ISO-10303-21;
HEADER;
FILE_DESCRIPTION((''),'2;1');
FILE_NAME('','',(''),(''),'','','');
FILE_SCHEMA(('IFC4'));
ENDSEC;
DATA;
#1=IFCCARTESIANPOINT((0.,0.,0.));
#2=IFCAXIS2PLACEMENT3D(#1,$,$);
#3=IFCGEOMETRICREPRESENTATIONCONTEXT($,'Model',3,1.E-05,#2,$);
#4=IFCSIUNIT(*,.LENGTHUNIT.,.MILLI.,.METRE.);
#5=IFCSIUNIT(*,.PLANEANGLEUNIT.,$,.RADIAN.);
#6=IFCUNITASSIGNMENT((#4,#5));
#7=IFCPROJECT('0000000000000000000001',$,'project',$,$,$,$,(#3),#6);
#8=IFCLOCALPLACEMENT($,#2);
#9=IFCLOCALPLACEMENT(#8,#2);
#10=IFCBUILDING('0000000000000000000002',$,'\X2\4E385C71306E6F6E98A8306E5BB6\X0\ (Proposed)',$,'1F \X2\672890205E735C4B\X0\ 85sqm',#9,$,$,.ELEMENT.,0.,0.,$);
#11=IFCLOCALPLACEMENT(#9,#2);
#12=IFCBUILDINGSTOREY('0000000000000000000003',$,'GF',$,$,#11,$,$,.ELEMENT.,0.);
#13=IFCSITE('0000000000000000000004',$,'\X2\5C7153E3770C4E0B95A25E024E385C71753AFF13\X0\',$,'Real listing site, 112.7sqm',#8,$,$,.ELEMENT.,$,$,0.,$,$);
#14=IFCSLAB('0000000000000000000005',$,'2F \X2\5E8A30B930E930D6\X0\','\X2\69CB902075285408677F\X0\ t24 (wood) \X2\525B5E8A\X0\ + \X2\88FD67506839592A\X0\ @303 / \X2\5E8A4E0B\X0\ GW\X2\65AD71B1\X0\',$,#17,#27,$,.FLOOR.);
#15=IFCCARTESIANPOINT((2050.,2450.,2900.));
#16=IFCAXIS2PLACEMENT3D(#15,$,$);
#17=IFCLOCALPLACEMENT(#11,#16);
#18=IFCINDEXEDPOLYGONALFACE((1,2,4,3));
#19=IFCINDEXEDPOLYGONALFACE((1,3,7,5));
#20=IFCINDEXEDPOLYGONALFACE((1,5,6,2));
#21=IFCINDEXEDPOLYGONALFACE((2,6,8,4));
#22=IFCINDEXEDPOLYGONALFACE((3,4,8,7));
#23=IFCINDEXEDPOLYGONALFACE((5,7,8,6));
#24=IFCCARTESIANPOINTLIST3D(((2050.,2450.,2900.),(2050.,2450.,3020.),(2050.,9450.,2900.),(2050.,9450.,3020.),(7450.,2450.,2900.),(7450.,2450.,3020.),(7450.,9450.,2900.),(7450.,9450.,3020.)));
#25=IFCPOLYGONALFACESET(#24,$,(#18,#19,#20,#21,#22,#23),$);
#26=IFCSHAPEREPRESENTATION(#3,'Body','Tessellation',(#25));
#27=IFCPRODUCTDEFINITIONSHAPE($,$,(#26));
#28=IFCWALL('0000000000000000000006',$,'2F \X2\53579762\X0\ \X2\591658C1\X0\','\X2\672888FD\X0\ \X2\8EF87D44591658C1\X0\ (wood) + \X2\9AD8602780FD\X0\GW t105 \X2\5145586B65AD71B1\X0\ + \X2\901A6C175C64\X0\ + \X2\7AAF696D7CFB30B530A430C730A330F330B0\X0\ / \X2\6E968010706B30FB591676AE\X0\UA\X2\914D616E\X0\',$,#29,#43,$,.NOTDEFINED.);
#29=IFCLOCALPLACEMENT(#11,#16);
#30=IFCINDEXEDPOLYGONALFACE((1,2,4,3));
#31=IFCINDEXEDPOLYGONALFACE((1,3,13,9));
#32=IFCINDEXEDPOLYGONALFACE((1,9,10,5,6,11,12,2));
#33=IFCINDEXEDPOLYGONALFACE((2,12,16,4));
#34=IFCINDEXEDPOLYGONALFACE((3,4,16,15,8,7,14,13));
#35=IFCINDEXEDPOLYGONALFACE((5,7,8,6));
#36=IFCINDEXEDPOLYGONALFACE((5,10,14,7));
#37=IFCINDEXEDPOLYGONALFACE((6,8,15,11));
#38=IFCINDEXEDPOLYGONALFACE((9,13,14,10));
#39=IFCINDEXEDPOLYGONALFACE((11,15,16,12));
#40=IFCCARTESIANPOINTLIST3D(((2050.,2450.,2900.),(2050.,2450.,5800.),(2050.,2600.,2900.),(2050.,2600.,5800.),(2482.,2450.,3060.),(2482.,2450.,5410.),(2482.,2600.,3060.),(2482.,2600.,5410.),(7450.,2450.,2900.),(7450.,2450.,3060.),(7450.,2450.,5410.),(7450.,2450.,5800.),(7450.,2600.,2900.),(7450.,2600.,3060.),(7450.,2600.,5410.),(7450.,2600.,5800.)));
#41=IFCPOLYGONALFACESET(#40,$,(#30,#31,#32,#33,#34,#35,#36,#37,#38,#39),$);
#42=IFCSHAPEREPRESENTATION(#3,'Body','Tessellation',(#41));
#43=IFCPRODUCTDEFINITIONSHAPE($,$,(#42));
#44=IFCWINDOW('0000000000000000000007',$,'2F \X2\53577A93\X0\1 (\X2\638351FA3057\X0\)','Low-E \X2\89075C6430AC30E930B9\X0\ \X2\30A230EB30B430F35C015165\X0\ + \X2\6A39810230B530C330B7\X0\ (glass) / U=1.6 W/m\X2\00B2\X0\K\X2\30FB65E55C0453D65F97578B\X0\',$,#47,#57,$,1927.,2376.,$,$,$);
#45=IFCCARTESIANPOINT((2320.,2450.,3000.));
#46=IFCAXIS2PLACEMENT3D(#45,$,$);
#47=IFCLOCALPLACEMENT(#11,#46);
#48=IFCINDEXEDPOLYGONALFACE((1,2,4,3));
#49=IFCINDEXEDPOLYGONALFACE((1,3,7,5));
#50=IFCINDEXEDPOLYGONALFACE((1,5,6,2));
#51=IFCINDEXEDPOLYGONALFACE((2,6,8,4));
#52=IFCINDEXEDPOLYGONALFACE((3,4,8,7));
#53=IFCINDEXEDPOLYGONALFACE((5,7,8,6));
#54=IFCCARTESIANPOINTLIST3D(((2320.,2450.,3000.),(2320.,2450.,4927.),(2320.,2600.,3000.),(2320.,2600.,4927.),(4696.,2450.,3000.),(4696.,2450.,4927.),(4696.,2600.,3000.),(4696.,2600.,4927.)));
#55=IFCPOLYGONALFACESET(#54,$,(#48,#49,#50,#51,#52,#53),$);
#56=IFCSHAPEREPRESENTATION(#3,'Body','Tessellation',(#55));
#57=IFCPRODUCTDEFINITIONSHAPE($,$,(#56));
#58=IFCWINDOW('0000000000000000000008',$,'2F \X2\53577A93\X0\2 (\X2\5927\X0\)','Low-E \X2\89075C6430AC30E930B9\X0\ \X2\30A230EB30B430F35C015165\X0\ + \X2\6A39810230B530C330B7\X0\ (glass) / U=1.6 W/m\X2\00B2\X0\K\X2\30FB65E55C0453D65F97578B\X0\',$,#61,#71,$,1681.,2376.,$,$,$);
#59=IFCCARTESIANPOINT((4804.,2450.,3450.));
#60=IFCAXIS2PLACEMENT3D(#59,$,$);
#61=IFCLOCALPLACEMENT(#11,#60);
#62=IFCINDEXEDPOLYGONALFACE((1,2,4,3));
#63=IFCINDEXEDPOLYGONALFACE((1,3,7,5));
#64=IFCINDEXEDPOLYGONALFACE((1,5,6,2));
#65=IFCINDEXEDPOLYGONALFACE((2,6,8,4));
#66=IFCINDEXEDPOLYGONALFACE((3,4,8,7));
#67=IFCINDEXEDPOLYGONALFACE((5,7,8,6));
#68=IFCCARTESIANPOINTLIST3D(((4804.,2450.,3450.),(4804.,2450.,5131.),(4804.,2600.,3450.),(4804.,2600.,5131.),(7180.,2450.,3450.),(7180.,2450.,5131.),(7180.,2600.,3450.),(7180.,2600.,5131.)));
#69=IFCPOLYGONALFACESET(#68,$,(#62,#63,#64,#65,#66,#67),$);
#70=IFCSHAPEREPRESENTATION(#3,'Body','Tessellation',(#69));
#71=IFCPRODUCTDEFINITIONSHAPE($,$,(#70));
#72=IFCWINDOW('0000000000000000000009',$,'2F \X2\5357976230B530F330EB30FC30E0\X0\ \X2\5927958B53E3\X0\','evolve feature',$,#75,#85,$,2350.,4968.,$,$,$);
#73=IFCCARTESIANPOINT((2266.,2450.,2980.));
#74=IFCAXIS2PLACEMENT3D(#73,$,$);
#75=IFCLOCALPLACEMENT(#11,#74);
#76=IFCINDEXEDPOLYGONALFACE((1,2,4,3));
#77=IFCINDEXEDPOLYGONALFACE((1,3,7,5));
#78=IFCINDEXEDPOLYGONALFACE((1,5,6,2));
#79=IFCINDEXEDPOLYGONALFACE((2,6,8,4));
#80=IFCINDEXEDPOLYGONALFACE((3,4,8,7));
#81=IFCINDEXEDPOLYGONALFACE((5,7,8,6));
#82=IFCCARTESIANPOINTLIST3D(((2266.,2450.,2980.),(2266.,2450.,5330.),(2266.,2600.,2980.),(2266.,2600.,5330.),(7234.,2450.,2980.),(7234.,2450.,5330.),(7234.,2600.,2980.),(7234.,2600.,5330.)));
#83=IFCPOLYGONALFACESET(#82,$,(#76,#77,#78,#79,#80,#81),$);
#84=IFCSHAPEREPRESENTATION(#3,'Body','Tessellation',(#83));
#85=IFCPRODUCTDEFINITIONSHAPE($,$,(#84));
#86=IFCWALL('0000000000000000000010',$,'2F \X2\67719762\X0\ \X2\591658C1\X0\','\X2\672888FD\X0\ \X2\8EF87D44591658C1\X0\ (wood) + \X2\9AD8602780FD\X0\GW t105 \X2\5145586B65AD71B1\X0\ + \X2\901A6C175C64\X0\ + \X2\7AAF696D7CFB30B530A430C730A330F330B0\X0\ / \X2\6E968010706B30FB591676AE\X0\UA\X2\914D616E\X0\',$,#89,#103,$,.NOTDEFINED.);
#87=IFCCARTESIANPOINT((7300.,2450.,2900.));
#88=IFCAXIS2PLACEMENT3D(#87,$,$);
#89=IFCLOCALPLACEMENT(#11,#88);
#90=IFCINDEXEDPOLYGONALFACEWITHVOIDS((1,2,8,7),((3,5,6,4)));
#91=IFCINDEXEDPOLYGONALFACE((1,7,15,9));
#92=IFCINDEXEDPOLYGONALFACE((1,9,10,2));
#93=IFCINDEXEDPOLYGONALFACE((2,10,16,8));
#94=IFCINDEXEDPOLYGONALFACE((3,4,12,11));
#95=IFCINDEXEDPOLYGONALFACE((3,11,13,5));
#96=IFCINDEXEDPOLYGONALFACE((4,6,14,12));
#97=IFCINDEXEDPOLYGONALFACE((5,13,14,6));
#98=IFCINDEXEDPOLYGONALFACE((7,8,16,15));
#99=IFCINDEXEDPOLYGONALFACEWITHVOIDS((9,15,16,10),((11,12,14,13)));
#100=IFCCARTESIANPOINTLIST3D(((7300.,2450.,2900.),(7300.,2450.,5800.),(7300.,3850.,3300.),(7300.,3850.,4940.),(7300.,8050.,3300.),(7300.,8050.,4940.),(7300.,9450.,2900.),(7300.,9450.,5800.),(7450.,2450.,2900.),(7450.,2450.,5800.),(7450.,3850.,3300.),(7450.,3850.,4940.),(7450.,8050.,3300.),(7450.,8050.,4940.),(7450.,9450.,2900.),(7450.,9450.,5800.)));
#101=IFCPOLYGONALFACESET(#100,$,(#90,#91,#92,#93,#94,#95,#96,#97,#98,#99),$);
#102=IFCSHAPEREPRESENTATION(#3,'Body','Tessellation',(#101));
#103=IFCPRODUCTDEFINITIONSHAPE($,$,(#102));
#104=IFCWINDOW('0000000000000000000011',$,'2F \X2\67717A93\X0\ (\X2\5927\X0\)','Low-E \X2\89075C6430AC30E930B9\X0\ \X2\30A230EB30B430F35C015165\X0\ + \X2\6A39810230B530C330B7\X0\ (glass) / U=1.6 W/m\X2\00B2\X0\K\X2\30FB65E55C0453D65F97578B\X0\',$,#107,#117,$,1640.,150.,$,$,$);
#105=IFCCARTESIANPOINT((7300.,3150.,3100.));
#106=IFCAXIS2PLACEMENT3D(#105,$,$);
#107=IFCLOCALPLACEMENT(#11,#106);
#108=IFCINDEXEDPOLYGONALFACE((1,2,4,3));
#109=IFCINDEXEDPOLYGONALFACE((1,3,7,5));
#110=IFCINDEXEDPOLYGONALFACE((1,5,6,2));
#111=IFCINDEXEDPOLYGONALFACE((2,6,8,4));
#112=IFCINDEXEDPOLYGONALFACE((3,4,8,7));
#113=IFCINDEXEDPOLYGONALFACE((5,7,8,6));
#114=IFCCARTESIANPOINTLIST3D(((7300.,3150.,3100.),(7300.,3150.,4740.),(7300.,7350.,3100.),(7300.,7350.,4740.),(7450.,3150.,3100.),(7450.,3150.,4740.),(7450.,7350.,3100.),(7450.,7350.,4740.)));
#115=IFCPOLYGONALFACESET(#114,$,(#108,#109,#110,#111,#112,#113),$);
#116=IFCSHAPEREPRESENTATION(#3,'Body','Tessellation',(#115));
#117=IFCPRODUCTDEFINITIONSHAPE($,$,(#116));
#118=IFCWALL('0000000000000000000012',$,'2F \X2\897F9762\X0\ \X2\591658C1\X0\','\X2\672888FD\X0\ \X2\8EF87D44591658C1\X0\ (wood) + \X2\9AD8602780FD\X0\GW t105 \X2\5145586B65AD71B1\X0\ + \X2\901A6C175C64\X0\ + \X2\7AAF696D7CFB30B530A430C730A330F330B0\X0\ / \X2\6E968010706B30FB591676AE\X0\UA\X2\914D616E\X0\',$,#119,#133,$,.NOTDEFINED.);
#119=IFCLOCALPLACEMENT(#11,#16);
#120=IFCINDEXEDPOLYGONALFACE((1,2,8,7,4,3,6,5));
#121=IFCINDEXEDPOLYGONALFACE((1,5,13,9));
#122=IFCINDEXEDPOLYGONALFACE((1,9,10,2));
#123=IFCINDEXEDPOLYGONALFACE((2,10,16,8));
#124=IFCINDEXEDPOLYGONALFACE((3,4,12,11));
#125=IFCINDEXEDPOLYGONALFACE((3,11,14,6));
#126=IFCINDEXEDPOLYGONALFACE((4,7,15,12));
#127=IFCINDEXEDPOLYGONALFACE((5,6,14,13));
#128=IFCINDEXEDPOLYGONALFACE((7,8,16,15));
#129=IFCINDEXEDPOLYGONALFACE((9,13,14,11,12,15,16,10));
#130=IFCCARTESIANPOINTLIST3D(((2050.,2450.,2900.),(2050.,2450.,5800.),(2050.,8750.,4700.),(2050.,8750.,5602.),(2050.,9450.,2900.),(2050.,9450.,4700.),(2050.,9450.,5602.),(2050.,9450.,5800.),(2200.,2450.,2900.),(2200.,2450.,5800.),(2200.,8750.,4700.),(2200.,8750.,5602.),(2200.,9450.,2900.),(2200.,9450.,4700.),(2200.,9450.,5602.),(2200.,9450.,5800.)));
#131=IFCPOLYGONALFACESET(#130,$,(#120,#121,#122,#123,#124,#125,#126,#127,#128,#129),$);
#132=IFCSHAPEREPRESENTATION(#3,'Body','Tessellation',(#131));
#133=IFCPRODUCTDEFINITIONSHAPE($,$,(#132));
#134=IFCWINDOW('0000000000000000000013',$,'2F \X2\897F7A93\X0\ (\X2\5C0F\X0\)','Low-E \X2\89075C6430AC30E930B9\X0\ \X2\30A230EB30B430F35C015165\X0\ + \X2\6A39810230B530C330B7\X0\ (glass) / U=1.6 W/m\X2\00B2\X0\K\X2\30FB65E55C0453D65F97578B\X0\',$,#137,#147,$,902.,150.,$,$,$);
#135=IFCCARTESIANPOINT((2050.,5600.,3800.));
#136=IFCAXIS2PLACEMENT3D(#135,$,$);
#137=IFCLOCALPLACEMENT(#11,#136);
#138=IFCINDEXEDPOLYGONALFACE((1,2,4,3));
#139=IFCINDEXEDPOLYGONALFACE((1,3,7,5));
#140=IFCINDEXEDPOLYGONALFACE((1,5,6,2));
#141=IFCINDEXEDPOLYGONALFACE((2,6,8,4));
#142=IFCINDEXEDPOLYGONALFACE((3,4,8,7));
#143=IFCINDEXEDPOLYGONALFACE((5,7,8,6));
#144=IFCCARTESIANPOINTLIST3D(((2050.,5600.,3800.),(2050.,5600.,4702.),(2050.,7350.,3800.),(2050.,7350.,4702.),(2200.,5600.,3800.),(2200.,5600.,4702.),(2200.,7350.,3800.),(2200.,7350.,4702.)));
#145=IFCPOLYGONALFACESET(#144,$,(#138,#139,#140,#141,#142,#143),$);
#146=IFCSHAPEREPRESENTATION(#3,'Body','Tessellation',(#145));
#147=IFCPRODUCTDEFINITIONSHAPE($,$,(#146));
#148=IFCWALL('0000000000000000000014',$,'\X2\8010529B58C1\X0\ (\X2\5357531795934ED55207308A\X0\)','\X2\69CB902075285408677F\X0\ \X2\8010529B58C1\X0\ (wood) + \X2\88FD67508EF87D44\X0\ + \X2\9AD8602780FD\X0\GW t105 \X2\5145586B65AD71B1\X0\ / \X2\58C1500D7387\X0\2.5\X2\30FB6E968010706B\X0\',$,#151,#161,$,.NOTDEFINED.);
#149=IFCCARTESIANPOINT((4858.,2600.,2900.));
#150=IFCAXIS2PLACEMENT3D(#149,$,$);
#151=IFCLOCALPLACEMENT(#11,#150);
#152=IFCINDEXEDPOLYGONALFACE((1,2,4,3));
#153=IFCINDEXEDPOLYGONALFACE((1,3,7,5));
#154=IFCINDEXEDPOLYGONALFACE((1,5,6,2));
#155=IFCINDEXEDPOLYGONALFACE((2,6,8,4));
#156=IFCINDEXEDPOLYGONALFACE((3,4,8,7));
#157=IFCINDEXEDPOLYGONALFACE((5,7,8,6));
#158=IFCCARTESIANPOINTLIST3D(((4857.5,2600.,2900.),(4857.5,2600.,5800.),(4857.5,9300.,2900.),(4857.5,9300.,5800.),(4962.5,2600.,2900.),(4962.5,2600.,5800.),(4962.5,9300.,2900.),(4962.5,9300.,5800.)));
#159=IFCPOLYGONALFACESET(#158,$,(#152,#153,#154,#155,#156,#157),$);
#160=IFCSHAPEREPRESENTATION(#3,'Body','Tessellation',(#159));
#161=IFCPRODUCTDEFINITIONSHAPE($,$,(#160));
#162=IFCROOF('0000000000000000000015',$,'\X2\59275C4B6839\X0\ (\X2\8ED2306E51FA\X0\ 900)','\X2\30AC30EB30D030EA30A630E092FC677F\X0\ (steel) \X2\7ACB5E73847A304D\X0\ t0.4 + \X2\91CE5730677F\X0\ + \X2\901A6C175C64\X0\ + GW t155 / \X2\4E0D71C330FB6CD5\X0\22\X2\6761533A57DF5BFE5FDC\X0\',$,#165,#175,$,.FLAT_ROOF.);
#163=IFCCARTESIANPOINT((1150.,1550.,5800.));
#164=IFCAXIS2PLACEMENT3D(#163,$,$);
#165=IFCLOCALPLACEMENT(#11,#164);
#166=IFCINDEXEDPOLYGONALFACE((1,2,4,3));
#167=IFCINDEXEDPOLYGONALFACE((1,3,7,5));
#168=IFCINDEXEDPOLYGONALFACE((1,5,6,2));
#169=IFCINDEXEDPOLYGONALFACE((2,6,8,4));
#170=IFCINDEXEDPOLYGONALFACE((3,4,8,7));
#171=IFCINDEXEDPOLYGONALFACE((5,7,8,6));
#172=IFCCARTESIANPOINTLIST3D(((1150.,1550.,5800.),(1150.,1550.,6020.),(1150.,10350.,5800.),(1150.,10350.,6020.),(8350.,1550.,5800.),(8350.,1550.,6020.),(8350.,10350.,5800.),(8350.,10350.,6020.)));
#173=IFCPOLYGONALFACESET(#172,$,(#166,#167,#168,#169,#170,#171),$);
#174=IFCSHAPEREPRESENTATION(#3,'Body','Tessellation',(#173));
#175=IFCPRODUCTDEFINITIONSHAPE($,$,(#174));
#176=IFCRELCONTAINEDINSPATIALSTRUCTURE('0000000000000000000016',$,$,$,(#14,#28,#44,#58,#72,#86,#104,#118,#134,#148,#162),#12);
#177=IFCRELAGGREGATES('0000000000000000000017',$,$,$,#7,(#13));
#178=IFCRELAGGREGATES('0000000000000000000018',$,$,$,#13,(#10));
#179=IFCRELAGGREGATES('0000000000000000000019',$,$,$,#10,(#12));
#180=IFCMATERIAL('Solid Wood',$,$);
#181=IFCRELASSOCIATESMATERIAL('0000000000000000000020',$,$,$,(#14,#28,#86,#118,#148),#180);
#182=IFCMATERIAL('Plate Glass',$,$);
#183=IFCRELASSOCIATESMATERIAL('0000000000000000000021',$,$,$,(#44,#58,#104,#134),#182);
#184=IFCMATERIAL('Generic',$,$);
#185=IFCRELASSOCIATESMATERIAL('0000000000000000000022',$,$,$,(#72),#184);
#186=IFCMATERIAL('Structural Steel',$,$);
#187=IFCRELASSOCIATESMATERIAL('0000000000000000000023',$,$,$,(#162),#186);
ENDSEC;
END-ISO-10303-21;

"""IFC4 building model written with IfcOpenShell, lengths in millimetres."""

from ifc_helpers import new_model, si_unit, frame, frame_2d, origin, place, context, project, spatial, rectangle, extrude, material, element, fill, save


model = new_model("IFC4")

# Units and contexts
model_context = context("Model", 3, precision=1e-05, world=origin())
ifc_project = project(units=[si_unit("LENGTHUNIT", "METRE", prefix="MILLI"), si_unit("PLANEANGLEUNIT", "RADIAN")], contexts=[model_context])

# Site, building, storey
site_placement = place(None, origin())
site = spatial("IfcSite", under=ifc_project, at=site_placement, Name="山口県下関市丸山町３", ObjectType="Real listing site, 112.7sqm", CompositionType="ELEMENT", RefElevation=0.0)
building_placement = place(site_placement, origin())
building = spatial("IfcBuilding", under=site, at=building_placement, Name="丸山の潮風の家 (Proposed)", ObjectType="1F 木造平屋 85sqm", CompositionType="ELEMENT", ElevationOfRefHeight=0.0, ElevationOfTerrain=0.0)
storey_placement = place(building_placement, origin())
storey = spatial("IfcBuildingStorey", under=building, at=storey_placement, Name="GF", CompositionType="ELEMENT", Elevation=0.0)

# Slab
ifc_material_1 = material(Name="Solid Wood")
slab_placement = place(storey_placement, frame((2050.0, 2450.0, 2900.0)))
element("IfcSlab", 1, at=slab_placement, inside=storey, material=ifc_material_1, Name="2F 床スラブ", Description="構造用合板 t24 (wood) 剛床 + 製材根太 @303 / 床下 GW断熱", PredefinedType="FLOOR", context=model_context, shape_type="SweptSolid", body=[
    extrude(rectangle(XDim=5400.0, YDim=7000.0, at=frame_2d((2700.0, 3500.0))), frame((2050.0, 2450.0, 2900.0)), (0.0, 0.0, 1.0), 120.0),
])

# Wall, openings, windows
wall_1_placement = place(storey_placement, frame((2050.0, 2450.0, 2900.0)))
wall_1 = element("IfcWall", 2, at=wall_1_placement, inside=storey, material=ifc_material_1, Name="2F 南面 外壁", Description="木製 軸組外壁 (wood) + 高性能GW t105 充填断熱 + 通気層 + 窯業系サイディング / 準耐火・外皮UA配慮", PredefinedType="NOTDEFINED", context=model_context, shape_type="SweptSolid", body=[
    extrude(rectangle(XDim=5400.0, YDim=150.0, at=frame_2d((2700.0, 75.0))), frame((2050.0, 2450.0, 2900.0)), (0.0, 0.0, 1.0), 2900.0),
])
opening_1_placement = place(storey_placement, frame((2320.0, 2450.0, 3000.0)))
opening_1 = element("IfcOpeningElement", 3, at=opening_1_placement, cuts=wall_1, PredefinedType="NOTDEFINED", context=model_context, shape_type="SweptSolid", body=[
    extrude(rectangle(XDim=2376.0, YDim=150.0, at=frame_2d((1188.0, 75.0))), frame((2320.0, 2450.0, 3000.0)), (0.0, 0.0, 1.0), 1927.0),
])
opening_2_placement = place(storey_placement, frame((4804.0, 2450.0, 3450.0)))
opening_2 = element("IfcOpeningElement", 4, at=opening_2_placement, cuts=wall_1, PredefinedType="NOTDEFINED", context=model_context, shape_type="SweptSolid", body=[
    extrude(rectangle(XDim=2376.0, YDim=150.0, at=frame_2d((1188.0, 75.0))), frame((4804.0, 2450.0, 3450.0)), (0.0, 0.0, 1.0), 1681.0),
])
opening_3_placement = place(storey_placement, frame((2266.0, 2450.0, 2980.0)))
opening_3 = element("IfcOpeningElement", 5, at=opening_3_placement, cuts=wall_1, PredefinedType="NOTDEFINED", context=model_context, shape_type="SweptSolid", body=[
    extrude(rectangle(XDim=4968.0, YDim=150.0, at=frame_2d((2484.0, 75.0))), frame((2266.0, 2450.0, 2980.0)), (0.0, 0.0, 1.0), 2350.0),
])
ifc_material_2 = material(Name="Plate Glass")
window_1_placement = place(storey_placement, frame((2320.0, 2450.0, 3000.0)))
window_1 = element("IfcWindow", 6, at=window_1_placement, inside=storey, material=ifc_material_2, Name="2F 南窓1 (掃出し)", Description="Low-E 複層ガラス アルゴン封入 + 樹脂サッシ (glass) / U=1.6 W/m²K・日射取得型", OverallHeight=1927.0, OverallWidth=2376.0, context=model_context, shape_type="SweptSolid", body=[
    extrude(rectangle(XDim=2376.0, YDim=150.0, at=frame_2d((1188.0, 75.0))), frame((2320.0, 2450.0, 3000.0)), (0.0, 0.0, 1.0), 1927.0),
])
fill(opening_1, window_1)
window_2_placement = place(storey_placement, frame((4804.0, 2450.0, 3450.0)))
window_2 = element("IfcWindow", 7, at=window_2_placement, inside=storey, material=ifc_material_2, Name="2F 南窓2 (大)", Description="Low-E 複層ガラス アルゴン封入 + 樹脂サッシ (glass) / U=1.6 W/m²K・日射取得型", OverallHeight=1681.0, OverallWidth=2376.0, context=model_context, shape_type="SweptSolid", body=[
    extrude(rectangle(XDim=2376.0, YDim=150.0, at=frame_2d((1188.0, 75.0))), frame((4804.0, 2450.0, 3450.0)), (0.0, 0.0, 1.0), 1681.0),
])
fill(opening_2, window_2)
ifc_material_3 = material(Name="Generic")
window_3_placement = place(storey_placement, frame((2266.0, 2450.0, 2980.0)))
window_3 = element("IfcWindow", 8, at=window_3_placement, inside=storey, material=ifc_material_3, Name="2F 南面サンルーム 大開口", Description="evolve feature", OverallHeight=2350.0, OverallWidth=4968.0, context=model_context, shape_type="SweptSolid", body=[
    extrude(rectangle(XDim=4968.0, YDim=150.0, at=frame_2d((2484.0, 75.0))), frame((2266.0, 2450.0, 2980.0)), (0.0, 0.0, 1.0), 2350.0),
])
fill(opening_3, window_3)

# Walls, openings, windows
wall_2_placement = place(storey_placement, frame((7300.0, 2450.0, 2900.0)))
wall_2 = element("IfcWall", 9, at=wall_2_placement, inside=storey, material=ifc_material_1, Name="2F 東面 外壁", Description="木製 軸組外壁 (wood) + 高性能GW t105 充填断熱 + 通気層 + 窯業系サイディング / 準耐火・外皮UA配慮", PredefinedType="NOTDEFINED", context=model_context, shape_type="SweptSolid", body=[
    extrude(rectangle(XDim=150.0, YDim=7000.0, at=frame_2d((75.0, 3500.0))), frame((7300.0, 2450.0, 2900.0)), (0.0, 0.0, 1.0), 2900.0),
])
opening_4_placement = place(storey_placement, frame((7300.0, 3150.0, 3100.0)))
opening_4 = element("IfcOpeningElement", 10, at=opening_4_placement, cuts=wall_2, PredefinedType="NOTDEFINED", context=model_context, shape_type="SweptSolid", body=[
    extrude(rectangle(XDim=150.0, YDim=4200.0, at=frame_2d((75.0, 2100.0))), frame((7300.0, 3150.0, 3100.0)), (0.0, 0.0, 1.0), 1640.0),
])
window_4_placement = place(storey_placement, frame((7300.0, 3150.0, 3100.0)))
window_4 = element("IfcWindow", 11, at=window_4_placement, inside=storey, material=ifc_material_2, Name="2F 東窓 (大)", Description="Low-E 複層ガラス アルゴン封入 + 樹脂サッシ (glass) / U=1.6 W/m²K・日射取得型", OverallHeight=1640.0, OverallWidth=150.0, context=model_context, shape_type="SweptSolid", body=[
    extrude(rectangle(XDim=150.0, YDim=4200.0, at=frame_2d((75.0, 2100.0))), frame((7300.0, 3150.0, 3100.0)), (0.0, 0.0, 1.0), 1640.0),
])
fill(opening_4, window_4)
wall_3_placement = place(storey_placement, frame((2050.0, 2450.0, 2900.0)))
wall_3 = element("IfcWall", 12, at=wall_3_placement, inside=storey, material=ifc_material_1, Name="2F 西面 外壁", Description="木製 軸組外壁 (wood) + 高性能GW t105 充填断熱 + 通気層 + 窯業系サイディング / 準耐火・外皮UA配慮", PredefinedType="NOTDEFINED", context=model_context, shape_type="SweptSolid", body=[
    extrude(rectangle(XDim=150.0, YDim=7000.0, at=frame_2d((75.0, 3500.0))), frame((2050.0, 2450.0, 2900.0)), (0.0, 0.0, 1.0), 2900.0),
])
opening_5_placement = place(storey_placement, frame((2050.0, 5600.0, 3800.0)))
opening_5 = element("IfcOpeningElement", 13, at=opening_5_placement, cuts=wall_3, PredefinedType="NOTDEFINED", context=model_context, shape_type="SweptSolid", body=[
    extrude(rectangle(XDim=150.0, YDim=1750.0, at=frame_2d((75.0, 875.0))), frame((2050.0, 5600.0, 3800.0)), (0.0, 0.0, 1.0), 902.0),
])
window_5_placement = place(storey_placement, frame((2050.0, 5600.0, 3800.0)))
window_5 = element("IfcWindow", 14, at=window_5_placement, inside=storey, material=ifc_material_2, Name="2F 西窓 (小)", Description="Low-E 複層ガラス アルゴン封入 + 樹脂サッシ (glass) / U=1.6 W/m²K・日射取得型", OverallHeight=902.0, OverallWidth=150.0, context=model_context, shape_type="SweptSolid", body=[
    extrude(rectangle(XDim=150.0, YDim=1750.0, at=frame_2d((75.0, 875.0))), frame((2050.0, 5600.0, 3800.0)), (0.0, 0.0, 1.0), 902.0),
])
fill(opening_5, window_5)

# Wall
wall_4_placement = place(storey_placement, frame((4858.0, 2600.0, 2900.0)))
element("IfcWall", 15, at=wall_4_placement, inside=storey, material=ifc_material_1, Name="耐力壁 (南北間仕切り)", Description="構造用合板 耐力壁 (wood) + 製材軸組 + 高性能GW t105 充填断熱 / 壁倍率2.5・準耐火", PredefinedType="NOTDEFINED", context=model_context, shape_type="SweptSolid", body=[
    extrude(rectangle(XDim=105.0, YDim=6700.0, at=frame_2d((52.0, 3350.0))), frame((4858.0, 2600.0, 2900.0)), (0.0, 0.0, 1.0), 2900.0),
])

# Roof
ifc_material_4 = material(Name="Structural Steel")
roof_placement = place(storey_placement, frame((1150.0, 1550.0, 5800.0)))
element("IfcRoof", 16, at=roof_placement, inside=storey, material=ifc_material_4, Name="大屋根 (軒の出 900)", Description="ガルバリウム鋼板 (steel) 立平葺き t0.4 + 野地板 + 通気層 + GW t155 / 不燃・法22条区域対応", PredefinedType="FLAT_ROOF", context=model_context, shape_type="SweptSolid", body=[
    extrude(rectangle(XDim=7200.0, YDim=8800.0, at=frame_2d((3600.0, 4400.0))), frame((1150.0, 1550.0, 5800.0)), (0.0, 0.0, 1.0), 220.0),
])

save(model, "model.ifc")
